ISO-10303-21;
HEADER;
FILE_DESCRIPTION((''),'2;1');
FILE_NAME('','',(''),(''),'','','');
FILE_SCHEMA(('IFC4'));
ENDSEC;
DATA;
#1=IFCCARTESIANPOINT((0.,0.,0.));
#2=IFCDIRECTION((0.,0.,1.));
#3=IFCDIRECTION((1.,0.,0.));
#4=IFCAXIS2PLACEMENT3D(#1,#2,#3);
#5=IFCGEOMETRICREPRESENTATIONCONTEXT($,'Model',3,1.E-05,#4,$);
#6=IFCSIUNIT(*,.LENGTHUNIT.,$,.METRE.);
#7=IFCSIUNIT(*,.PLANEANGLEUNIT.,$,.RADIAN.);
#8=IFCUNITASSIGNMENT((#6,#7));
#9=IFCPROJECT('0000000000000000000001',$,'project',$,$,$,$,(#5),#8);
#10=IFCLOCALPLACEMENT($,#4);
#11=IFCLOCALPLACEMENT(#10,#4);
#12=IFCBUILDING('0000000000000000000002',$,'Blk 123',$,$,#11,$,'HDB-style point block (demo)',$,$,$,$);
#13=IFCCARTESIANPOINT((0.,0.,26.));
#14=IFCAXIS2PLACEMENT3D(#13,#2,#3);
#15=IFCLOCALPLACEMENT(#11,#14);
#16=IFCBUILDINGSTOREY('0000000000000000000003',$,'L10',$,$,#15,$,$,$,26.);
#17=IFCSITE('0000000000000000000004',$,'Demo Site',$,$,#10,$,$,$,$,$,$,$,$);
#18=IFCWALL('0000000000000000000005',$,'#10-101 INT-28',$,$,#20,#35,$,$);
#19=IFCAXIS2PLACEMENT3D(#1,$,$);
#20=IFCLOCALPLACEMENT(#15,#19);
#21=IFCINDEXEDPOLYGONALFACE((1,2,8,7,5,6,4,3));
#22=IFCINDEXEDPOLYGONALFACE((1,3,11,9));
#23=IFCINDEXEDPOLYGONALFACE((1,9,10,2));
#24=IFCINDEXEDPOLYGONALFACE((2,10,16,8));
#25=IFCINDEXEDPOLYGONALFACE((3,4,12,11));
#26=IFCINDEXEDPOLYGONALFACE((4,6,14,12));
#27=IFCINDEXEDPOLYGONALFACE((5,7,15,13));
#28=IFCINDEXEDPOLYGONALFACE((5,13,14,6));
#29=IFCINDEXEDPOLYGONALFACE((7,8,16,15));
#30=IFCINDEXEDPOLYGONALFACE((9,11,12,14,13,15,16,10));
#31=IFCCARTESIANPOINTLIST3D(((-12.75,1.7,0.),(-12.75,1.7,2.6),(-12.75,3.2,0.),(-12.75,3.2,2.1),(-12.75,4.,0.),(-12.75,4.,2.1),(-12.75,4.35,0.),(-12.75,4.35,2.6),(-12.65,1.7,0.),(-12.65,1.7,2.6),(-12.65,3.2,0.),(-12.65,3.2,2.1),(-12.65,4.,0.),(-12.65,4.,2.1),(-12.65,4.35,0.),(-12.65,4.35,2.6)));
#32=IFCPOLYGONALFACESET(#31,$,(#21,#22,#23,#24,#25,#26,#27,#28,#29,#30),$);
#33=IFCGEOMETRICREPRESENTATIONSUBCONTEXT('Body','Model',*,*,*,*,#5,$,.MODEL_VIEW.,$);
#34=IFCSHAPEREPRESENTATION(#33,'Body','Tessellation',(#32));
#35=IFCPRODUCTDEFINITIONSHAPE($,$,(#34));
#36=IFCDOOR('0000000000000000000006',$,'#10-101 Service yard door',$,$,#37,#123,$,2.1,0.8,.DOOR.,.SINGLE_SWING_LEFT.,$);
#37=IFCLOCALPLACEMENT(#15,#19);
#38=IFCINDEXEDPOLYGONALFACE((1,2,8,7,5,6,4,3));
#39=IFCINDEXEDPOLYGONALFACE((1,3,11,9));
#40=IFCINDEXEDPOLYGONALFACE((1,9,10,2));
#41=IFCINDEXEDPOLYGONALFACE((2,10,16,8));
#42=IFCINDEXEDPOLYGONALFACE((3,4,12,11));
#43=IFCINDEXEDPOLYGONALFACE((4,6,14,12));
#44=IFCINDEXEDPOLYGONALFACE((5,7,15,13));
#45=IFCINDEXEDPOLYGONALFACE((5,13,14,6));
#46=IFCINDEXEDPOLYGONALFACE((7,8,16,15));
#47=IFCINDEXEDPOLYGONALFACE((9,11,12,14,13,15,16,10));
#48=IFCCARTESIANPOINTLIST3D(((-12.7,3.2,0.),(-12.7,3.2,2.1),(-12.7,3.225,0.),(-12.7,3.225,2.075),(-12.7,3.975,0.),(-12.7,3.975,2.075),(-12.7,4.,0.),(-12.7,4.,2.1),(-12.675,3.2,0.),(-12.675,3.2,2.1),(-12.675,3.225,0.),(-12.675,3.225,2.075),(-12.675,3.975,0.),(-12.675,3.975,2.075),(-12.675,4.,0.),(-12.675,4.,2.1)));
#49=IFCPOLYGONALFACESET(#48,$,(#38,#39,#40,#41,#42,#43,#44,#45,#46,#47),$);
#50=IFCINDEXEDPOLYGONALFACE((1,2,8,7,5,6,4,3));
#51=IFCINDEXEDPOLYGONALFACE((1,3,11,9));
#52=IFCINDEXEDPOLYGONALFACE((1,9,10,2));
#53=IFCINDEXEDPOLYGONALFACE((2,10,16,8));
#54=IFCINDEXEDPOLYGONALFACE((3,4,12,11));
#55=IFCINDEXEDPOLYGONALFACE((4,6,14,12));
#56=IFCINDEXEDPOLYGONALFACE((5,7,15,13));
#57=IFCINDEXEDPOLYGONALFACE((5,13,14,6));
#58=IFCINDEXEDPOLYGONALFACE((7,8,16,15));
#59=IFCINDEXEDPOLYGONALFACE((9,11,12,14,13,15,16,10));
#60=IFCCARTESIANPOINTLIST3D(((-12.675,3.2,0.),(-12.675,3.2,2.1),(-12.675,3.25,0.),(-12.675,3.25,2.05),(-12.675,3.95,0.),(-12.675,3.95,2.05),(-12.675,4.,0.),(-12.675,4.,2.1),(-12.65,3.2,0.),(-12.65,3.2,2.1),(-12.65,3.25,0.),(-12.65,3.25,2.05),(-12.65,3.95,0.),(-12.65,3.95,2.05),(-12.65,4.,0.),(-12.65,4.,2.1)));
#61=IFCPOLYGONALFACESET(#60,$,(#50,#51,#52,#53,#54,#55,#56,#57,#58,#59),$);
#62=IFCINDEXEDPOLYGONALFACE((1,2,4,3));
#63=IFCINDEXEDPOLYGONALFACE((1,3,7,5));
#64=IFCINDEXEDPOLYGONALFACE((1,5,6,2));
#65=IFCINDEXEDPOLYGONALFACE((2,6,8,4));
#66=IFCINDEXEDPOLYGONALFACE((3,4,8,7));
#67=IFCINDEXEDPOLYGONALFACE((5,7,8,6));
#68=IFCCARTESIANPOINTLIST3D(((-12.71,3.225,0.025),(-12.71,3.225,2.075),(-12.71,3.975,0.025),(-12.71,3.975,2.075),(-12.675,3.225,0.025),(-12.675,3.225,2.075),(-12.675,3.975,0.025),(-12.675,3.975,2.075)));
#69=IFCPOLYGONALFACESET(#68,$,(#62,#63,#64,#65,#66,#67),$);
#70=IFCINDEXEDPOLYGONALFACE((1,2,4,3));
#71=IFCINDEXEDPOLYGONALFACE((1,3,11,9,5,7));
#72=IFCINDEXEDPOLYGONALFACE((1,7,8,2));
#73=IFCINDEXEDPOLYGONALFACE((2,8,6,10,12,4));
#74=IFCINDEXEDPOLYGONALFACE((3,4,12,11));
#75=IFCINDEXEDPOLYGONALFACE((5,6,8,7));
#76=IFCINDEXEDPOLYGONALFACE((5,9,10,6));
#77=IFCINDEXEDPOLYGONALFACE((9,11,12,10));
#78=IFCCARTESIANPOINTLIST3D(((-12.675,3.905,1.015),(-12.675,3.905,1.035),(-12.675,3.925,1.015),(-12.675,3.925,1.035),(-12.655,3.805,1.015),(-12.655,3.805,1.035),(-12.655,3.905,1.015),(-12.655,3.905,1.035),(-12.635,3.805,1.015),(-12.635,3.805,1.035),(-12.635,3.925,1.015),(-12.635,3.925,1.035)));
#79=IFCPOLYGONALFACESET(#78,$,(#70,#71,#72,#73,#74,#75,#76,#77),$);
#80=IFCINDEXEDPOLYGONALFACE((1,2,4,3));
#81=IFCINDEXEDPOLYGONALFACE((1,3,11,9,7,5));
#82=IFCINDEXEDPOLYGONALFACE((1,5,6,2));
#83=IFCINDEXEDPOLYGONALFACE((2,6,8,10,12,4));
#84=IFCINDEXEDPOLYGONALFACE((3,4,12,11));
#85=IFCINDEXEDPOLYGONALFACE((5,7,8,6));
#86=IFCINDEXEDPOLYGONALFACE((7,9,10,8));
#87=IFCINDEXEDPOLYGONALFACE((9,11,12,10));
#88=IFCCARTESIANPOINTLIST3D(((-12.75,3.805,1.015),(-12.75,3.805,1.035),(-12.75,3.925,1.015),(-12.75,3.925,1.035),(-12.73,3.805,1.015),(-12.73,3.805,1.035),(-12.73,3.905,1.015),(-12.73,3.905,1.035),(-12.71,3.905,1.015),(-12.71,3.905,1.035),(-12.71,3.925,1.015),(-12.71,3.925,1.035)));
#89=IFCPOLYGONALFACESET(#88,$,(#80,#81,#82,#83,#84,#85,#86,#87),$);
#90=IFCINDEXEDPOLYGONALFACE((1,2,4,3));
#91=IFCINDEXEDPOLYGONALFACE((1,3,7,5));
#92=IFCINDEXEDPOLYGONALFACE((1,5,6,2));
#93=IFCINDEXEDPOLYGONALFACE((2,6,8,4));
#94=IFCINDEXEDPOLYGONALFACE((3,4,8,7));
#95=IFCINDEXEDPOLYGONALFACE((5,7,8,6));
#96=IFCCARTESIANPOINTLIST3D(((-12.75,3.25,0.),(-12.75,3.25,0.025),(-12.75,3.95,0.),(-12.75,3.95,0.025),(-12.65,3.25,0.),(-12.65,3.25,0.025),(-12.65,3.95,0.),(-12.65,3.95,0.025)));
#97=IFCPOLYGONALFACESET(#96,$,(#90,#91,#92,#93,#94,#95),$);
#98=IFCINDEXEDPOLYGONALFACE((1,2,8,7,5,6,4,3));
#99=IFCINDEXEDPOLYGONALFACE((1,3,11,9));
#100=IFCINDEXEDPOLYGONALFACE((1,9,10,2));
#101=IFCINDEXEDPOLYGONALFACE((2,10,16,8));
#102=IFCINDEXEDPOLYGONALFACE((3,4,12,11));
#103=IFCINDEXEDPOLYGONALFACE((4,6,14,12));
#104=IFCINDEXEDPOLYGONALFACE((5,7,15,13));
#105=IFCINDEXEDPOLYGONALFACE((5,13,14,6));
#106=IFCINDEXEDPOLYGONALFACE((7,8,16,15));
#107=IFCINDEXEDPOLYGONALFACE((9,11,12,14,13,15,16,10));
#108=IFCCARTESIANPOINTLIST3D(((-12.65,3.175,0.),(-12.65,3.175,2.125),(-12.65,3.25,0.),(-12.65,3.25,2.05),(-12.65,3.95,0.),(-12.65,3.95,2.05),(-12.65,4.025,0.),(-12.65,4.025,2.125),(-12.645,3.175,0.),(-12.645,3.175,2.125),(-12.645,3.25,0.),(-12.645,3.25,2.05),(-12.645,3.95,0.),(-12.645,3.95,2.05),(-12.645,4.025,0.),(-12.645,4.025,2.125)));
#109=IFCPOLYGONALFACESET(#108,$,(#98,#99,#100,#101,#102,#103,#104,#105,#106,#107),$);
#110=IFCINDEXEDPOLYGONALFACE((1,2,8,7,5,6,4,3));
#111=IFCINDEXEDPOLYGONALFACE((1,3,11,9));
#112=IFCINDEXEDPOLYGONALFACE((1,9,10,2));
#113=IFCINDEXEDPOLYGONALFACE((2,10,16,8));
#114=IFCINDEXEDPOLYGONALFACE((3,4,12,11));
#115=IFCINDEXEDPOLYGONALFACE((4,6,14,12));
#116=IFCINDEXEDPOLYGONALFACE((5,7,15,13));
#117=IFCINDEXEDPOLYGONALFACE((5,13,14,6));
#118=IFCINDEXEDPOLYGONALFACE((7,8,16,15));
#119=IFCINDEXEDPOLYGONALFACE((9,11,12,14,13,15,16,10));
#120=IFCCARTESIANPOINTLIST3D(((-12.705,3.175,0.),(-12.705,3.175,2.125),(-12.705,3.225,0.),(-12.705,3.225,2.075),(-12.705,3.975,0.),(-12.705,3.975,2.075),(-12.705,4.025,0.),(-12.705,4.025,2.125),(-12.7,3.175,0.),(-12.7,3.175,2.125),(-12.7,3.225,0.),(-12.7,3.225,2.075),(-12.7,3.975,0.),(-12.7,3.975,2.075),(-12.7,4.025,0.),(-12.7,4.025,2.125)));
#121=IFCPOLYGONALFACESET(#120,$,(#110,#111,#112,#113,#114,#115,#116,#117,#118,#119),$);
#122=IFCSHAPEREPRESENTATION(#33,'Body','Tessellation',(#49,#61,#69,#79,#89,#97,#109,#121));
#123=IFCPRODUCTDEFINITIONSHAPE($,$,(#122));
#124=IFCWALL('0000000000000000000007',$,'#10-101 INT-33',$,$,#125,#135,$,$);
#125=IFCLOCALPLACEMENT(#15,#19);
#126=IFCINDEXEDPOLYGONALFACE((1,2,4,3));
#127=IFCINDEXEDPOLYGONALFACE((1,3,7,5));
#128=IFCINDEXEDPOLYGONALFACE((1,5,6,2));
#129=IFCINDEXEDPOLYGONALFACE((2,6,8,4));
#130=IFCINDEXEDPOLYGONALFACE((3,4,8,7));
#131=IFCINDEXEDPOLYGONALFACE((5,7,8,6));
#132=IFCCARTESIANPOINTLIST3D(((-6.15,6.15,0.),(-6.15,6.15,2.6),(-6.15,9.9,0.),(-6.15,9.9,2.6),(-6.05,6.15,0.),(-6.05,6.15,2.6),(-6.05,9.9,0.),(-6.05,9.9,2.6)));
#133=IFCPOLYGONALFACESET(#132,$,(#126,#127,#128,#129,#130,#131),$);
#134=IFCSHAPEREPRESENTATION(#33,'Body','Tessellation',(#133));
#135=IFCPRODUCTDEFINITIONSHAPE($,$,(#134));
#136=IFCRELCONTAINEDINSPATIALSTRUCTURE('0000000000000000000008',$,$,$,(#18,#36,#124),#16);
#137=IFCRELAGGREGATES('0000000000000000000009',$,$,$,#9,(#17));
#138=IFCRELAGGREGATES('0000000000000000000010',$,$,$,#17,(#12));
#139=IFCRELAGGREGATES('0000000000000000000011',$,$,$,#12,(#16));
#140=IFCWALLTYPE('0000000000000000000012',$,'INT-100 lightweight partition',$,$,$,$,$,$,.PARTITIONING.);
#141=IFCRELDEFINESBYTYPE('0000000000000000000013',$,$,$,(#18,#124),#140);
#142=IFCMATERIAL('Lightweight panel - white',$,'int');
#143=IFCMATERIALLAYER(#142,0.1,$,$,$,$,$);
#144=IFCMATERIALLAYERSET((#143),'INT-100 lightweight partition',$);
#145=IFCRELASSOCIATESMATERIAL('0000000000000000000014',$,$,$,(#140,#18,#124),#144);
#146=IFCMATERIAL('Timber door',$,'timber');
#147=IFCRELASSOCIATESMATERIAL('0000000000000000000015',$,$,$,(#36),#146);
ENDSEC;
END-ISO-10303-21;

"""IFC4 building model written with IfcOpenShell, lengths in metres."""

from ifc_helpers import new_model, si_unit, frame, origin_with_axes, place, context, subcontext, project, spatial, line, indexed_curve, outline, extrude, material, layer, layer_set, layer_usage, type_object, element, fill, save


model = new_model("IFC4")

# Units and contexts
model_context = context("Model", 3, precision=1e-05, world=origin_with_axes())
body_context = subcontext(model_context, "Body", "Model", "MODEL_VIEW")
ifc_project = project(units=[si_unit("LENGTHUNIT", "METRE"), si_unit("PLANEANGLEUNIT", "RADIAN")], contexts=[model_context])

# Site, building, storey
site_placement = place(None, origin_with_axes())
site = spatial("IfcSite", under=ifc_project, at=site_placement, Name="Demo Site")
building_placement = place(site_placement, origin_with_axes())
building = spatial("IfcBuilding", under=site, at=building_placement, Name="Blk 123", LongName="HDB-style point block (demo)")
storey_placement = place(building_placement, frame((0.0, 0.0, 26.0), z_axis=(0.0, 0.0, 1.0), x_axis=(1.0, 0.0, 0.0)))
storey = spatial("IfcBuildingStorey", under=building, at=storey_placement, Name="L10", Elevation=26.0)

# Shared definitions
ifc_material_1 = material(Name="Timber door", Category="timber")

# Shared definitions
ifc_material_2 = material(Name="Lightweight panel - white", Category="int")
ifc_layer_1 = layer(ifc_material_2, 0.1)
ifc_layer_set_1 = layer_set([ifc_layer_1], Name="INT-100 lightweight partition")
ifc_layer_usage_1 = layer_usage(ifc_layer_set_1, "AXIS2", "POSITIVE", -0.05)
wall_type_1 = type_object("IfcWallType", Name="INT-100 lightweight partition", PredefinedType="PARTITIONING", material=ifc_layer_set_1)

# Wall, opening, door
wall_1_placement = place(storey_placement, frame((-12.7, 1.7, 0.0), z_axis=(0.0, 0.0, 1.0), x_axis=(0.0, 1.0, 0.0)))
wall_1 = element("IfcWall", 1, at=wall_1_placement, inside=storey, type_object=wall_type_1, material=ifc_layer_usage_1, Name="#10-101 INT-28", context=body_context, shape_type="SweptSolid", body=[
    extrude(outline(indexed_curve([(0.0, 0.0), (0.0, 0.1), (2.65, 0.1), (2.65, 0.0), (0.0, 0.0)], self_intersect=False)), frame((0.0, -0.05, 0.0), z_axis=(0.0, 0.0, 1.0), x_axis=(1.0, 0.0, 0.0)), (0.0, 0.0, 1.0), 2.6),
])
opening_1_placement = place(wall_1_placement, frame((1.5, -0.15, 0.0), z_axis=(0.0, 0.0, 1.0), x_axis=(1.0, 0.0, 0.0)))
opening_1 = element("IfcOpeningElement", 2, at=opening_1_placement, cuts=wall_1, context=body_context, shape_type="SweptSolid", body=[
    extrude(outline(indexed_curve([(0.0, 0.0), (0.0, 0.3), (0.8, 0.3), (0.8, 0.0), (0.0, 0.0)], self_intersect=False)), origin_with_axes(), (0.0, 0.0, 1.0), 2.1),
])
door_1_placement = place(opening_1_placement, frame((0.0, 0.1, 0.0), z_axis=(0.0, 0.0, 1.0), x_axis=(1.0, 0.0, 0.0)))
door_1 = element("IfcDoor", 3, at=door_1_placement, inside=storey, material=ifc_material_1, Name="#10-101 Service yard door", OperationType="SINGLE_SWING_LEFT", OverallHeight=2.1, OverallWidth=0.8, PredefinedType="DOOR", context=body_context, shape_type="SweptSolid", body=[
    extrude(outline(indexed_curve([(0.0, 0.0), (0.0, 2.1), (0.8, 2.1), (0.8, 0.0), (0.775, 0.0), (0.775, 2.075), (0.025, 2.075), (0.025, 0.0)], segments=[line(1, 2, 3, 4, 5, 6, 7, 8, 1)])), frame((0.0, 0.025, 0.0), z_axis=(0.0, -1.0, 0.0), x_axis=(1.0, 0.0, 0.0)), (0.0, 0.0, -1.0), 0.025),
    extrude(outline(indexed_curve([(0.0, 0.0), (0.0, 2.1), (0.8, 2.1), (0.8, 0.0), (0.75, 0.0), (0.75, 2.05), (0.05, 2.05), (0.05, 0.0)], segments=[line(1, 2, 3, 4, 5, 6, 7, 8, 1)])), frame((0.0, 0.0, 0.0), z_axis=(0.0, -1.0, 0.0), x_axis=(1.0, 0.0, 0.0)), (0.0, 0.0, -1.0), 0.025),
    extrude(outline(indexed_curve([(0.0, 0.0), (0.75, 0.0), (0.75, 0.035), (0.0, 0.035)], segments=[line(1, 2, 3, 4, 1)])), frame((0.025, 0.025, 0.025), z_axis=(0.0, 0.0, 1.0), x_axis=(1.0, 0.0, 0.0)), (0.0, 0.0, 1.0), 2.05),
    extrude(outline(indexed_curve([(0.0, 0.0), (0.0, -0.04), (-0.12, -0.04), (-0.12, -0.02), (-0.02, -0.02), (-0.02, 0.0)], segments=[line(1, 2, 3, 4, 5, 6, 1)])), frame((0.725, 0.025, 1.015), z_axis=(0.0, 0.0, 1.0), x_axis=(1.0, 0.0, 0.0)), (0.0, 0.0, 1.0), 0.02),
    extrude(outline(indexed_curve([(0.0, 0.0), (0.0, 0.04), (-0.12, 0.04), (-0.12, 0.02), (-0.02, 0.02), (-0.02, 0.0)], segments=[line(1, 2, 3, 4, 5, 6, 1)])), frame((0.725, 0.06, 1.015), z_axis=(0.0, 0.0, 1.0), x_axis=(1.0, 0.0, 0.0)), (0.0, 0.0, 1.0), 0.02),
    extrude(outline(indexed_curve([(0.0, 0.0), (0.7, 0.0), (0.7, 0.1), (0.0, 0.1)], segments=[line(1, 2, 3, 4, 1)])), frame((0.05, 0.0, 0.0), z_axis=(0.0, 0.0, 1.0), x_axis=(1.0, 0.0, 0.0)), (0.0, 0.0, 1.0), 0.025),
    extrude(outline(indexed_curve([(0.0, 0.0), (0.0, 2.125), (0.85, 2.125), (0.85, 0.0), (0.775, 0.0), (0.775, 2.05), (0.075, 2.05), (0.075, 0.0)], segments=[line(1, 2, 3, 4, 5, 6, 7, 8, 1)])), frame((-0.025, -0.005, 0.0), z_axis=(0.0, -1.0, 0.0), x_axis=(1.0, 0.0, 0.0)), (0.0, 0.0, -1.0), 0.005),
    extrude(outline(indexed_curve([(0.0, 0.0), (0.0, 2.125), (0.85, 2.125), (0.85, 0.0), (0.8, 0.0), (0.8, 2.075), (0.05, 2.075), (0.05, 0.0)], segments=[line(1, 2, 3, 4, 5, 6, 7, 8, 1)])), frame((-0.025, 0.05, 0.0), z_axis=(0.0, -1.0, 0.0), x_axis=(1.0, 0.0, 0.0)), (0.0, 0.0, -1.0), 0.005),
])
fill(opening_1, door_1)

# Wall
wall_2_placement = place(storey_placement, frame((-6.1, 6.15, 0.0), z_axis=(0.0, 0.0, 1.0), x_axis=(0.0, 1.0, 0.0)))
element("IfcWall", 4, at=wall_2_placement, inside=storey, type_object=wall_type_1, material=ifc_layer_usage_1, Name="#10-101 INT-33", context=body_context, shape_type="SweptSolid", body=[
    extrude(outline(indexed_curve([(0.0, 0.0), (0.0, 0.1), (3.75, 0.1), (3.75, 0.0), (0.0, 0.0)], self_intersect=False)), frame((0.0, -0.05, 0.0), z_axis=(0.0, 0.0, 1.0), x_axis=(1.0, 0.0, 0.0)), (0.0, 0.0, 1.0), 2.6),
])

save(model, "model.ifc")
